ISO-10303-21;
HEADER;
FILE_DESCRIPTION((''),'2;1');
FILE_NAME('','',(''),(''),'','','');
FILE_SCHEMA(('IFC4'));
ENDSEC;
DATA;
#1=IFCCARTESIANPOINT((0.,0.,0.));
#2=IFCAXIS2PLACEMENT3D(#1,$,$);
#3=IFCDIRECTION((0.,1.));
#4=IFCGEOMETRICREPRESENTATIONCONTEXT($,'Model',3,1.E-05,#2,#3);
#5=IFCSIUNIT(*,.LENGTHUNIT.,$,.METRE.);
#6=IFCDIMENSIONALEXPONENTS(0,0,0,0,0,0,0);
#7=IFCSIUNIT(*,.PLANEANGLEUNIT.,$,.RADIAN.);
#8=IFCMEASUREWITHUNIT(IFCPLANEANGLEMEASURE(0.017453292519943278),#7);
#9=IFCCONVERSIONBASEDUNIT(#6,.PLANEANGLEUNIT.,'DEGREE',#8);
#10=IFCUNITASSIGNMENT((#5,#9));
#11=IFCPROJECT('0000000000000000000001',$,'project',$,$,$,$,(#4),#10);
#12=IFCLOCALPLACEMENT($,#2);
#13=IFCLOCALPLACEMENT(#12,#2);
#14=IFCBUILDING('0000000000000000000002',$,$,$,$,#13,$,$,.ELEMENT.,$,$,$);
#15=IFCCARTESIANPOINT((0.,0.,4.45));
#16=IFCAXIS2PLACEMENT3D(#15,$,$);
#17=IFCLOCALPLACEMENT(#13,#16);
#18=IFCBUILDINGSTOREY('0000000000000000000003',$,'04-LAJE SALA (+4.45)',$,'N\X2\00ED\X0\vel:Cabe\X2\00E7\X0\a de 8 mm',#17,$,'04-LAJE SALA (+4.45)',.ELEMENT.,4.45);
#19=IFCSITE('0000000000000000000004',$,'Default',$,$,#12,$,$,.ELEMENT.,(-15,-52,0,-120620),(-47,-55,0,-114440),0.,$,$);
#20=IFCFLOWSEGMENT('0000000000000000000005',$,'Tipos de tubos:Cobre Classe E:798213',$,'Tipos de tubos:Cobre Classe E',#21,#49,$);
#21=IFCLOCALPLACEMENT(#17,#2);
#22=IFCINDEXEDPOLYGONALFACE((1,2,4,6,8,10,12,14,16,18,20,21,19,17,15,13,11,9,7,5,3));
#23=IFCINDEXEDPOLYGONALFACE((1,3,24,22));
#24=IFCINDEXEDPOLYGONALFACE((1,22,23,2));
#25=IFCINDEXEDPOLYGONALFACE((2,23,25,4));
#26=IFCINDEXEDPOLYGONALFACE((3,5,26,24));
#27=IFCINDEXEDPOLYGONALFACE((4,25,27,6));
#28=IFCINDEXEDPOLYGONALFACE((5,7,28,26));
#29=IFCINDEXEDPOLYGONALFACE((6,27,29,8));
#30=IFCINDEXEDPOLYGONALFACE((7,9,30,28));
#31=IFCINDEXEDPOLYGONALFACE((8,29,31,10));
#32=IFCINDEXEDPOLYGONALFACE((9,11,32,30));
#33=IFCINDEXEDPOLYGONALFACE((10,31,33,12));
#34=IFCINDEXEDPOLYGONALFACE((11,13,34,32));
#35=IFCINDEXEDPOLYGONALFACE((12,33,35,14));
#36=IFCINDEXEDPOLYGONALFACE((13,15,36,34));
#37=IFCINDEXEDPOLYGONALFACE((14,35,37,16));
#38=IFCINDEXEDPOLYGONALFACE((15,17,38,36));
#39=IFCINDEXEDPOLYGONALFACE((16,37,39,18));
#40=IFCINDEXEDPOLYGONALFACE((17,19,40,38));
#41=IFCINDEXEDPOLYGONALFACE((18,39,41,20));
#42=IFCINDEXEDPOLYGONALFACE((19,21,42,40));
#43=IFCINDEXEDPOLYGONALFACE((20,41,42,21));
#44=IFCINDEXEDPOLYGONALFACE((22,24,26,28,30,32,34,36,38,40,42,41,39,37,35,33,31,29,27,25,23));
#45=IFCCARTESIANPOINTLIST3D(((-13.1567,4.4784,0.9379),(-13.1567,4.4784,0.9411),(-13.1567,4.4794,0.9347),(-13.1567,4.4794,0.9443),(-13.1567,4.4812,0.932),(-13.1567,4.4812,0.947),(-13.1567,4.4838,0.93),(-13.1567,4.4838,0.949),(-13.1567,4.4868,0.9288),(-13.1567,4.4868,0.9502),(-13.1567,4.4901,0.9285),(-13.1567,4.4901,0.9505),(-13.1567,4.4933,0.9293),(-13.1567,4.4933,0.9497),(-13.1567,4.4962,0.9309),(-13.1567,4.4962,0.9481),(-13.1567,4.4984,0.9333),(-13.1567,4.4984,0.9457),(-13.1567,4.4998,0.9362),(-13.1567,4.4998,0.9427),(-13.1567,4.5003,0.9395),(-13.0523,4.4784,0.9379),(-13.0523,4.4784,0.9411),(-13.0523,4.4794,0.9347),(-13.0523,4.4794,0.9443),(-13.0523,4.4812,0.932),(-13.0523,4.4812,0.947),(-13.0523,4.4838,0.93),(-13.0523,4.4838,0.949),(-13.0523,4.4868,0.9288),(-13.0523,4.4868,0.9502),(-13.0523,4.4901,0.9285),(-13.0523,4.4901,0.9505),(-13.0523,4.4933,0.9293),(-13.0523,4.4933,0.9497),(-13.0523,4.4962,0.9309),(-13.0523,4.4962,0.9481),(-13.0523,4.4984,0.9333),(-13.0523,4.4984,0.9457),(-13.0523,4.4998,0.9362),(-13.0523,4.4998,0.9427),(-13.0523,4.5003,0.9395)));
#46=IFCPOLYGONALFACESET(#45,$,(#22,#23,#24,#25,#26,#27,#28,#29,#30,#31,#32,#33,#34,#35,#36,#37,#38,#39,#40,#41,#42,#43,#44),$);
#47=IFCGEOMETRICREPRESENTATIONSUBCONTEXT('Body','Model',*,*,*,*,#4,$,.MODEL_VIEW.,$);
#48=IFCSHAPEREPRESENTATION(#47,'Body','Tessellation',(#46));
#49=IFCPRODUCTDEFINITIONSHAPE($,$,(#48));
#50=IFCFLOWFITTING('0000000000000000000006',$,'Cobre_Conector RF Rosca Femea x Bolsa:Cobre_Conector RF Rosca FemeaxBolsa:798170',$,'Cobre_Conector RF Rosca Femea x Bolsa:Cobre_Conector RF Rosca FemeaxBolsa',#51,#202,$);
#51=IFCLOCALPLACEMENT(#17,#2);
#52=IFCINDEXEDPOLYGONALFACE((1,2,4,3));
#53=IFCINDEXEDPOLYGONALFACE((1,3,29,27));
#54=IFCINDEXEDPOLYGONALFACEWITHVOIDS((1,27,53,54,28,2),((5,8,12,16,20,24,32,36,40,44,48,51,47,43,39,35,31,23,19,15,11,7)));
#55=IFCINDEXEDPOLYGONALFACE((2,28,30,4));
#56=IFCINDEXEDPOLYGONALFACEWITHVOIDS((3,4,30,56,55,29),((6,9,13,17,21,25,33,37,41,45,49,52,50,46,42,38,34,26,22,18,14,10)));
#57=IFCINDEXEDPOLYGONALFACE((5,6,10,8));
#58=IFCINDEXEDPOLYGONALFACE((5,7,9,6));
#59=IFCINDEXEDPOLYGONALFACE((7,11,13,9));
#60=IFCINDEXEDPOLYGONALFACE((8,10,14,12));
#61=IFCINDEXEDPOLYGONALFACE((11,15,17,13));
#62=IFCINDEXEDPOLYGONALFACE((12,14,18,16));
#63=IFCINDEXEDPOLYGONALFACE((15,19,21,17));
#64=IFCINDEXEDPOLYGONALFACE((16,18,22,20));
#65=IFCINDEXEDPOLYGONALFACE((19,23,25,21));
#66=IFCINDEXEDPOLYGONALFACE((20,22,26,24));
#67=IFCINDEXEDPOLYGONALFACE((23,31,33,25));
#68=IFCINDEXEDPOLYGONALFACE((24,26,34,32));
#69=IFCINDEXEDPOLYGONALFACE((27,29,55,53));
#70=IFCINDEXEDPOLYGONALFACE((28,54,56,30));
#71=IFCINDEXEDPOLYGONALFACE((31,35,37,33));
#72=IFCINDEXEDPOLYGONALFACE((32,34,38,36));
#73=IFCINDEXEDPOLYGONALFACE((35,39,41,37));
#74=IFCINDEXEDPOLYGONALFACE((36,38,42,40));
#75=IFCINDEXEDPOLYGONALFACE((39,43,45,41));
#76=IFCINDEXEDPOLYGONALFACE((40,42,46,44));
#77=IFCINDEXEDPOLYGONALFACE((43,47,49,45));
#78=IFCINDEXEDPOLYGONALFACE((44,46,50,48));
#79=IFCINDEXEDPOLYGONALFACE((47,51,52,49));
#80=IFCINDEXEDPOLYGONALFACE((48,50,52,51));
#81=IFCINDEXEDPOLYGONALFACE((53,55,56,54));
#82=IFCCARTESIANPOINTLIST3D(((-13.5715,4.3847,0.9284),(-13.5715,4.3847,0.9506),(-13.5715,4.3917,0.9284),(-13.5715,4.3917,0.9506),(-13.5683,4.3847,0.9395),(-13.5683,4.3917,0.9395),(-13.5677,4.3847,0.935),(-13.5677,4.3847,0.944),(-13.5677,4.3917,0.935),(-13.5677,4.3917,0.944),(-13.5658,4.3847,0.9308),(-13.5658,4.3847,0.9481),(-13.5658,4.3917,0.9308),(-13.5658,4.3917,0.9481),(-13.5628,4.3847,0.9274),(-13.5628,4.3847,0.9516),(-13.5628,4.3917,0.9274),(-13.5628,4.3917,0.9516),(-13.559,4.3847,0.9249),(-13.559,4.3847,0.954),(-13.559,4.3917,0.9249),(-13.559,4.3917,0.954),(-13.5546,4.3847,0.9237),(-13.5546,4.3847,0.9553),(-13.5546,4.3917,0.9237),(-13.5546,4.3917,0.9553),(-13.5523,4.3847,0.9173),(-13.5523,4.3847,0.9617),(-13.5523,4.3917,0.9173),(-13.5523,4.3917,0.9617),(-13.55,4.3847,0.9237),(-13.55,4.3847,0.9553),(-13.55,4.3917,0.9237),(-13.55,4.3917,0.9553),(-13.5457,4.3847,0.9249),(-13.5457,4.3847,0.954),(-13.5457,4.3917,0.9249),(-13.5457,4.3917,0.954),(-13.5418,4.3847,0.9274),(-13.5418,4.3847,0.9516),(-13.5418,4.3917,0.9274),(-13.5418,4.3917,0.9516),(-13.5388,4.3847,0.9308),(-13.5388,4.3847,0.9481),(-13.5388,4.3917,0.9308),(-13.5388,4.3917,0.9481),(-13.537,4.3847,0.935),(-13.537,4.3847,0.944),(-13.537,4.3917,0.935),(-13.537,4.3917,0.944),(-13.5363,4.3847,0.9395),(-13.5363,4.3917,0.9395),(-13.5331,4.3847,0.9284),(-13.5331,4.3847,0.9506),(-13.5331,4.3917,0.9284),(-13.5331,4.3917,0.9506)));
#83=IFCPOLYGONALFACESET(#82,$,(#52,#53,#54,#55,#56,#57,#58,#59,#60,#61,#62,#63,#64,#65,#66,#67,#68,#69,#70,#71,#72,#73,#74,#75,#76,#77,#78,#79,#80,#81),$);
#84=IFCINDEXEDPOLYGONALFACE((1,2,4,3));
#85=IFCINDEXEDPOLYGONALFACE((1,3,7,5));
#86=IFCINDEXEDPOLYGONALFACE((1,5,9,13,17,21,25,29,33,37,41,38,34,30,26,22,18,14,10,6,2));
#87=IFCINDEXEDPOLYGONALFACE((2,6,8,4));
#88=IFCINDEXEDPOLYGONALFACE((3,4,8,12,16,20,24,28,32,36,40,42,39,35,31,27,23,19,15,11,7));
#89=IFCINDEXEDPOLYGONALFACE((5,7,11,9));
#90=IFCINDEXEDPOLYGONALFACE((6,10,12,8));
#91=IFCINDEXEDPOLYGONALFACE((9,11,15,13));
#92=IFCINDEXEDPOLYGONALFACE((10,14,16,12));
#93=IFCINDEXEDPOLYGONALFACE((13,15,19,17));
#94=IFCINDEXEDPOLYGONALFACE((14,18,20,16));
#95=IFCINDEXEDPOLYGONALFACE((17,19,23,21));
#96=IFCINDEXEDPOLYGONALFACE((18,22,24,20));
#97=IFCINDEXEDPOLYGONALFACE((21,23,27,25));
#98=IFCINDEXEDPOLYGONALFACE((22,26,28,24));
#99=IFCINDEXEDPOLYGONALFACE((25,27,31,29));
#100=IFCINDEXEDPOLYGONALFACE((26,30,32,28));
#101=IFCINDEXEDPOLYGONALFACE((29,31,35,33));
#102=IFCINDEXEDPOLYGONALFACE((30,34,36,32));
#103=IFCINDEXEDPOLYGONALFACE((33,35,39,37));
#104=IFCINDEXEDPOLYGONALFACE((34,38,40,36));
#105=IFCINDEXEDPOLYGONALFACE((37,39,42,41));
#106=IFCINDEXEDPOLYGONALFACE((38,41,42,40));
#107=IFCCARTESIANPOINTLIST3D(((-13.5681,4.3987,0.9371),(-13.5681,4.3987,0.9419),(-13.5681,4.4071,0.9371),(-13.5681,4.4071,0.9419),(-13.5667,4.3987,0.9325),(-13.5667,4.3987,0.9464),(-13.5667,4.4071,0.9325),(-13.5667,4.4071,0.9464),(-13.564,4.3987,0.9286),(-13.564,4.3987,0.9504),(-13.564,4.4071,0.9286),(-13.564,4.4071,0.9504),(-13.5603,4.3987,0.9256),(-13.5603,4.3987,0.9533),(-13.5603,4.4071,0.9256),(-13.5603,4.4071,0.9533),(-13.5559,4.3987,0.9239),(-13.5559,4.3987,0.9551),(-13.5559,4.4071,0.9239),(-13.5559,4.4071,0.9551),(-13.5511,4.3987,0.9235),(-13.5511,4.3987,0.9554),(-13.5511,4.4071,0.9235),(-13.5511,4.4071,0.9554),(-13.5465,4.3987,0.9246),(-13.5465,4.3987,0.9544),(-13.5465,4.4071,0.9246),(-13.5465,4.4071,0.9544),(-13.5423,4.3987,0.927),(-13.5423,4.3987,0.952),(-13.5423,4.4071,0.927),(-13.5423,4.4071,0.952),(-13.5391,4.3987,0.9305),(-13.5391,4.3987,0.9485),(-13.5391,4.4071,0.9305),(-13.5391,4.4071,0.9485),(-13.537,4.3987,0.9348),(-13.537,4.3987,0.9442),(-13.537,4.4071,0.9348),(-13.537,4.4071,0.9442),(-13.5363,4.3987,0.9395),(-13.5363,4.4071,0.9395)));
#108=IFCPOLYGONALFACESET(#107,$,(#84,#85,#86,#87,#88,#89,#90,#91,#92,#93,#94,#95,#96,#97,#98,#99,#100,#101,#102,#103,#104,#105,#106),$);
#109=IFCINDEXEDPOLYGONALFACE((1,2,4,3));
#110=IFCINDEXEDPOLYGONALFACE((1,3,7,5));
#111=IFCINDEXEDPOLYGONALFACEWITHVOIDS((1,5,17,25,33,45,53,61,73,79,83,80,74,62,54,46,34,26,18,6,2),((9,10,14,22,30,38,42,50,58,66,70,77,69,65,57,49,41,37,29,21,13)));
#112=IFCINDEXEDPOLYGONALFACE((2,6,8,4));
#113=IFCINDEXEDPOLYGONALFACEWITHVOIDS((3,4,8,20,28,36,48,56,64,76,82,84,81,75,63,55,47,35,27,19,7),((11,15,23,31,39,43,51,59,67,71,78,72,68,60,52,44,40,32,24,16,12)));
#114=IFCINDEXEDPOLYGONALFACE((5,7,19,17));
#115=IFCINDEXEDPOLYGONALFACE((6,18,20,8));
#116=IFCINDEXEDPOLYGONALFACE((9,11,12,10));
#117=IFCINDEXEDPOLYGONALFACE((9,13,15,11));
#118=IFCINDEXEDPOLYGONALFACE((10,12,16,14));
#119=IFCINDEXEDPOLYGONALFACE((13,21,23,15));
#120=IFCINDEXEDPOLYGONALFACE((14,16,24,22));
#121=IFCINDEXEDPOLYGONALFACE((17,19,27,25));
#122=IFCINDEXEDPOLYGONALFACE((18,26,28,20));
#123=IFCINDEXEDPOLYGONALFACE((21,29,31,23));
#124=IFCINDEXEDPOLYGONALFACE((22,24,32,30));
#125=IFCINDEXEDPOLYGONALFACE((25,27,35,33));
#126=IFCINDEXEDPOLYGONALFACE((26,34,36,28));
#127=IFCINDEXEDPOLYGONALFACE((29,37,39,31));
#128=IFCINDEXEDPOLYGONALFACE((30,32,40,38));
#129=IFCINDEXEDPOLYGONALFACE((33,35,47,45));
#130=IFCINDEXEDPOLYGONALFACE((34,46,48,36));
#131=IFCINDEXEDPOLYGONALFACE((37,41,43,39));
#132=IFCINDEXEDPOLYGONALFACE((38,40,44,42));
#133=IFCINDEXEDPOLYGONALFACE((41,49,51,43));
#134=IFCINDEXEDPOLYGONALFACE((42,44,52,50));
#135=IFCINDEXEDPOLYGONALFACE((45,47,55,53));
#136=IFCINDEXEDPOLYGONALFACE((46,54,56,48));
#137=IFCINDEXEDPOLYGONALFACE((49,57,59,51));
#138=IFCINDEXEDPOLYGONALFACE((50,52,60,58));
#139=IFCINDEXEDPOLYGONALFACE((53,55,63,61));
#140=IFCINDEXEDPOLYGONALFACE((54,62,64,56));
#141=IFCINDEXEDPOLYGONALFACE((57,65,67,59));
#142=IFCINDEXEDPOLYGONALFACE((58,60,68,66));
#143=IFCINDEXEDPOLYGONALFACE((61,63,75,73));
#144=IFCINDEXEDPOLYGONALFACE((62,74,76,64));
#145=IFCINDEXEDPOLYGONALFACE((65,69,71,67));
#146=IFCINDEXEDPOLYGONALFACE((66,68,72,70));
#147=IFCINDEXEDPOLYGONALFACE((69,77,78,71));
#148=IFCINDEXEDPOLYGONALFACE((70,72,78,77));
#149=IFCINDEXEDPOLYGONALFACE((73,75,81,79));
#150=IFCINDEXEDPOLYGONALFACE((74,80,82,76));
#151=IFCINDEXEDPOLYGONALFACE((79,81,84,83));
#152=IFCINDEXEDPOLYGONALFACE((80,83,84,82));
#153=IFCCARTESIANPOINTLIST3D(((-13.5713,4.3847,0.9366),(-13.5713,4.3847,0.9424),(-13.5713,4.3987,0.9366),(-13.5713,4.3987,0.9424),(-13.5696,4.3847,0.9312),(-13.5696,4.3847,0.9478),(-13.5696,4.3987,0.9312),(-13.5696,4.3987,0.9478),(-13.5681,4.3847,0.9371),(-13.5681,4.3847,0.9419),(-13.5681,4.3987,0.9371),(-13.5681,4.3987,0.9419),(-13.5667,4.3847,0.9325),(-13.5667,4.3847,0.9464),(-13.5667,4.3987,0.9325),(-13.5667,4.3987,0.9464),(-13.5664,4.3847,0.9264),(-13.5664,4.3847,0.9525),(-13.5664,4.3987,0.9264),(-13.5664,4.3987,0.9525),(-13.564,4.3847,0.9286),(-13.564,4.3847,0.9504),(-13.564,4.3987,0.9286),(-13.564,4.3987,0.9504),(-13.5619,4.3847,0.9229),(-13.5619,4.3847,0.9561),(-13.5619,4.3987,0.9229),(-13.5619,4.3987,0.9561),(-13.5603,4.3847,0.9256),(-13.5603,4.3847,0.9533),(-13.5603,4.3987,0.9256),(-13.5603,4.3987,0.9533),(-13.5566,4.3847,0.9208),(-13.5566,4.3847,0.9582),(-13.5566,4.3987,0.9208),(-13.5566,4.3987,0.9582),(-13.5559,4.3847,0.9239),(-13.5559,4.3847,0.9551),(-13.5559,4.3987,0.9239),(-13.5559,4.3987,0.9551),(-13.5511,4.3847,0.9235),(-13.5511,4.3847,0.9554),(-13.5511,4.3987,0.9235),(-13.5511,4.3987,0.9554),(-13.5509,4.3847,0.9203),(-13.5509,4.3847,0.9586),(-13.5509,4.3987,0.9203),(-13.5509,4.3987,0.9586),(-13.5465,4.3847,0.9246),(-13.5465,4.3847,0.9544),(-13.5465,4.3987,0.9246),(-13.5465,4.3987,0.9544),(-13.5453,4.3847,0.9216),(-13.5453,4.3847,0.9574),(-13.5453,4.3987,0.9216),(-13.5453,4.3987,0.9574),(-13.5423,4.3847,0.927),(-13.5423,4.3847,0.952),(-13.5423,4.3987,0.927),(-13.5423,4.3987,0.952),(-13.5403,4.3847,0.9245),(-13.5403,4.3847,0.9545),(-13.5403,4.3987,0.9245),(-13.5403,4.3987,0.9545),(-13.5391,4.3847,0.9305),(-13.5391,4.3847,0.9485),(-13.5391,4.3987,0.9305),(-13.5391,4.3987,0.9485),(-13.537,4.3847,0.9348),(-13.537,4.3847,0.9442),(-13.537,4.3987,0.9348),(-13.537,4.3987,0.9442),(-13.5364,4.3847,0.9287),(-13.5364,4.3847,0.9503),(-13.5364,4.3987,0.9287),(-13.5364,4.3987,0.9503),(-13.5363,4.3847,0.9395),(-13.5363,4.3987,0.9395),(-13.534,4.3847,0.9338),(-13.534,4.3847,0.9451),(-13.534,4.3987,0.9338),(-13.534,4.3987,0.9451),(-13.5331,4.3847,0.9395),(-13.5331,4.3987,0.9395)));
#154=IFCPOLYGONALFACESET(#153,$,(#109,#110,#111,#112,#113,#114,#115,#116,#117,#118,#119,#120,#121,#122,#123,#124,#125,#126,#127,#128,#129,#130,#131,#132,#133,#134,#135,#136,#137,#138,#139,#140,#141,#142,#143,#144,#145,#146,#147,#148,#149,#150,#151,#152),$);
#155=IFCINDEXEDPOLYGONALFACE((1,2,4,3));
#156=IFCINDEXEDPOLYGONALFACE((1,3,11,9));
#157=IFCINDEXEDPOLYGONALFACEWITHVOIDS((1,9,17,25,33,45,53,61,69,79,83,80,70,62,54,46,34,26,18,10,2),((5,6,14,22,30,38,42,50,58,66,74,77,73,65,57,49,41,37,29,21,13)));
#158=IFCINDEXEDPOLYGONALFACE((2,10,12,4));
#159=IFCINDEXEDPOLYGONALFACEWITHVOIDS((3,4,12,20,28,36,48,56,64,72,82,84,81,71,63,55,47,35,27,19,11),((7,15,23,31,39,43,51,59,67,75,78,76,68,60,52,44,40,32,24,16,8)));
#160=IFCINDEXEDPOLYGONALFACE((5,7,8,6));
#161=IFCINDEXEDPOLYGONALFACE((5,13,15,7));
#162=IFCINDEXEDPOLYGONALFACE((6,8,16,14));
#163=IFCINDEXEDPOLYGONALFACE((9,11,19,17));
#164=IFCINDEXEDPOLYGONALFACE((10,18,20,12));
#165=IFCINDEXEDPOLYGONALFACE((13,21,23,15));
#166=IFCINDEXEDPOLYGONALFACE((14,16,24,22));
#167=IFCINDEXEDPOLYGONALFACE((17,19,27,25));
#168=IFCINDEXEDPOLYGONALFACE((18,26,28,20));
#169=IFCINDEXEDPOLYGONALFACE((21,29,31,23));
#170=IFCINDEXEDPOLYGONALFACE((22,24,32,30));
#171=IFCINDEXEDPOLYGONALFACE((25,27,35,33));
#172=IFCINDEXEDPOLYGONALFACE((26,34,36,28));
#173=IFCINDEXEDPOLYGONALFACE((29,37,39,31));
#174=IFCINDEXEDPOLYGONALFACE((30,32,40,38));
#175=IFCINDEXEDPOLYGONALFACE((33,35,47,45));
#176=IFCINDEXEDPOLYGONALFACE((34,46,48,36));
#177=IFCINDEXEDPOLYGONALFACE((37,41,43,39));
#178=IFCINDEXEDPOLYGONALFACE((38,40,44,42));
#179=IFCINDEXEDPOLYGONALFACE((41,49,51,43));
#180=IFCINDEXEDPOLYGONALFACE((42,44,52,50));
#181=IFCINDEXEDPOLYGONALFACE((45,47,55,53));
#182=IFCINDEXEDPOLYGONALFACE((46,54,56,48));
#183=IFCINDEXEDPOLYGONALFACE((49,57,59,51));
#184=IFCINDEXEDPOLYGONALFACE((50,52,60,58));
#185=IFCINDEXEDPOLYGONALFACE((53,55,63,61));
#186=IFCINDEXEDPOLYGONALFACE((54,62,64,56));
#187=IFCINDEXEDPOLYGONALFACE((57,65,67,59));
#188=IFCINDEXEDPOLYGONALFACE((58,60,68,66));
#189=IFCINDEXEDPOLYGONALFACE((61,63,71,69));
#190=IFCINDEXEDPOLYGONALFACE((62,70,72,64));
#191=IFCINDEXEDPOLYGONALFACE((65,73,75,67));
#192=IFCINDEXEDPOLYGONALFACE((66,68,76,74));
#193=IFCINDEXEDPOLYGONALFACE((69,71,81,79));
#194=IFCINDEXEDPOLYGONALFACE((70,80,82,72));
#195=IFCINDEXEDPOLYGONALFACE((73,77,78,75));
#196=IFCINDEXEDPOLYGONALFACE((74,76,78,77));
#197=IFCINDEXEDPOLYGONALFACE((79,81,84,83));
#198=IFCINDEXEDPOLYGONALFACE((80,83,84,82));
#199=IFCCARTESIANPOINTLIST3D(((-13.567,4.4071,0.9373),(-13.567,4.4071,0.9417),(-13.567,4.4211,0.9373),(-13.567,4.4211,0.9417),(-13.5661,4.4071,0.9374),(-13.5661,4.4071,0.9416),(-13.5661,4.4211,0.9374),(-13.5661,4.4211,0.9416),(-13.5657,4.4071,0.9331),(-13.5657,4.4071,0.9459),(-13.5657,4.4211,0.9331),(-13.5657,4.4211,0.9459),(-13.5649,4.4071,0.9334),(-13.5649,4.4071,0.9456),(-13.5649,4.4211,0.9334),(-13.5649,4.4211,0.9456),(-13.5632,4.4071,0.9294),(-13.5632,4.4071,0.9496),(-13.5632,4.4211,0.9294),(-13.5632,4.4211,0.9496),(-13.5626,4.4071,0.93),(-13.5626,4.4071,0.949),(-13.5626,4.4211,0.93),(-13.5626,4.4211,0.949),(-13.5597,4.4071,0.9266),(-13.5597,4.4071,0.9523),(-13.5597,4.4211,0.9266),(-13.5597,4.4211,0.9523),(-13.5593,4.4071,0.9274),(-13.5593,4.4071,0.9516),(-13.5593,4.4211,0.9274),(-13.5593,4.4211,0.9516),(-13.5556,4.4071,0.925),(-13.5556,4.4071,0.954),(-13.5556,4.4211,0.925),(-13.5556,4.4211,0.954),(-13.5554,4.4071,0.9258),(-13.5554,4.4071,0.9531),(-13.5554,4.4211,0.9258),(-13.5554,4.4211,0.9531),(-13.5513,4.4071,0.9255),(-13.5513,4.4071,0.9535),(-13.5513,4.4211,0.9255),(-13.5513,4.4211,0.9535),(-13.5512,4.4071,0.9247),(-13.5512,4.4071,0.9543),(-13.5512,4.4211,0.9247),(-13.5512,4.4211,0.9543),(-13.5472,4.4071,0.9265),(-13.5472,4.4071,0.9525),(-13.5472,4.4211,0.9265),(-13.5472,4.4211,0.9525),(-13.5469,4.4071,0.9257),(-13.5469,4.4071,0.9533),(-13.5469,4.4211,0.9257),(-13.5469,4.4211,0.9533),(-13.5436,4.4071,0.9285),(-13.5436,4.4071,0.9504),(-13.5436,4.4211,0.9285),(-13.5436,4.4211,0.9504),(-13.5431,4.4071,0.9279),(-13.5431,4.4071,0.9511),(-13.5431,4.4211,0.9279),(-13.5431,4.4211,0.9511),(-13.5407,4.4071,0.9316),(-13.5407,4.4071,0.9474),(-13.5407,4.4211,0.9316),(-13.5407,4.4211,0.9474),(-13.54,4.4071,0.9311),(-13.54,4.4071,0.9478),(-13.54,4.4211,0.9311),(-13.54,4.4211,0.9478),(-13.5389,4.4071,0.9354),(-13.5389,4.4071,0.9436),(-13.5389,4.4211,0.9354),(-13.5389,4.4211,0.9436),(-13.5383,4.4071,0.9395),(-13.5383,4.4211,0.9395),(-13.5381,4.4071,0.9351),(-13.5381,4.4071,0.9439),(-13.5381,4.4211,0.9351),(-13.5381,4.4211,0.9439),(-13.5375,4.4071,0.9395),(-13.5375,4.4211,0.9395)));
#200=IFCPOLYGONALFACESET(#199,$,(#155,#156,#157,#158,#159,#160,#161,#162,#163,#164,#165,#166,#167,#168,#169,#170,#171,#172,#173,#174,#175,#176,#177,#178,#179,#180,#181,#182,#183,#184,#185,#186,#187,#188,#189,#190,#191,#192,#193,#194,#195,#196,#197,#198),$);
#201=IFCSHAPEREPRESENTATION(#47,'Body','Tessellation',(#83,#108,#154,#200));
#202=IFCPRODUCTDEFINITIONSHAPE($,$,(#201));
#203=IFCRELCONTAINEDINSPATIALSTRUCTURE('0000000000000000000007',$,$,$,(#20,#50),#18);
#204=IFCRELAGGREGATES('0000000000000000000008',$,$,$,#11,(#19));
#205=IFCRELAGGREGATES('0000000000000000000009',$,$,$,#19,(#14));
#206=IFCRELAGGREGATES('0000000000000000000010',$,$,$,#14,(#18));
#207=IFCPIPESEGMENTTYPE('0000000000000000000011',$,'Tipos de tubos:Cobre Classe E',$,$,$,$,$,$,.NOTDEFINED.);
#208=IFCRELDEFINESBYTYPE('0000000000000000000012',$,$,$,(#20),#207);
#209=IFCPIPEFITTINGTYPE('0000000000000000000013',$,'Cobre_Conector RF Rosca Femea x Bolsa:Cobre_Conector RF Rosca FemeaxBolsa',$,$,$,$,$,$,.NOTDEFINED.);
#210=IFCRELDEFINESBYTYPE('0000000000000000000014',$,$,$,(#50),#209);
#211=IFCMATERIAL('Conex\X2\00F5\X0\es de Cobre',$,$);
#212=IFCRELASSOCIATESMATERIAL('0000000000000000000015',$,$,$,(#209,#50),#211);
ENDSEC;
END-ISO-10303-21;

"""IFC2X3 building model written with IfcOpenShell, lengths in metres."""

from ifc_helpers import new_model, entity, si_unit, converted_unit, direction, frame, frame_2d, origin, origin_2d_with_axis, place, context, subcontext, project, spatial, polyline, circle_curve, parameter, trimmed, segment, composite_curve, circle, hollow_circle, outline, extrude, source, transform, mapped, material, type_object, type_shapes, element, save


model = new_model("IFC2X3")

# Units and contexts
model_context = context("Model", 3, precision=1e-05, world=origin(), true_north=direction((0.0, 1.0)))
body_context = subcontext(model_context, "Body", "Model", "MODEL_VIEW")
ifc_project = project(units=[si_unit("LENGTHUNIT", "METRE"), converted_unit("PLANEANGLEUNIT", "DEGREE", entity("IfcPlaneAngleMeasure", 0.017453292519943278), si_unit("PLANEANGLEUNIT", "RADIAN"), dimensions=[0, 0, 0, 0, 0, 0, 0])], contexts=[model_context])

# Site, building, storey
site_placement = place(None, origin())
site = spatial("IfcSite", under=ifc_project, at=site_placement, Name="Default", CompositionType="ELEMENT", RefLatitude=(-15, -52, 0, -120620), RefLongitude=(-47, -55, 0, -114440), RefElevation=0.0)
building_placement = place(site_placement, origin())
building = spatial("IfcBuilding", under=site, at=building_placement, CompositionType="ELEMENT")
storey_placement = place(building_placement, frame((0.0, 0.0, 4.45)))
storey = spatial("IfcBuildingStorey", under=building, at=storey_placement, Name="04-LAJE SALA (+4.45)", ObjectType="Nível:Cabeça de 8 mm", LongName="04-LAJE SALA (+4.45)", CompositionType="ELEMENT", Elevation=4.45)

# Flow segment
pipe_segment_type_1 = type_object("IfcPipeSegmentType", Name="Tipos de tubos:Cobre Classe E", PredefinedType="NOTDEFINED")
flow_segment_1_placement = place(storey_placement, origin())
element("IfcFlowSegment", 1, at=flow_segment_1_placement, inside=storey, type_object=pipe_segment_type_1, Name="Tipos de tubos:Cobre Classe E:798213", ObjectType="Tipos de tubos:Cobre Classe E", context=body_context, shape_type="SweptSolid", body=[
    extrude(circle(Radius=0.011, at=origin_2d_with_axis()), frame((-13.1567, 4.4893, 0.9395), z_axis=(1.0, 0.0, 0.0), x_axis=(0.0, 1.0, 0.0)), (0.0, 0.0, 1.0), 0.1045),
])

# Flow fitting
ifc_material_1 = material(Name="Conexões de Cobre")
pipe_fitting_type_1 = type_object("IfcPipeFittingType", Name="Cobre_Conector RF Rosca Femea x Bolsa:Cobre_Conector RF Rosca FemeaxBolsa", PredefinedType="NOTDEFINED", material=ifc_material_1)
shared_shape_1 = source(origin(), body_context, "Body", "SweptSolid", [
    extrude(outline(polyline([(-0.0111, -0.0192), (0.0111, -0.0192), (0.0222, 0.0), (0.0111, 0.0192), (-0.0111, 0.0192), (-0.0222, 0.0), (-0.0111, -0.0192)]), holes=[composite_curve([segment(trimmed(circle_curve(frame_2d((0.0, 0.0), x_axis=(0.0, 1.0)), 0.016), [parameter(0.0)], [parameter(180.0)], True, "PARAMETER"), False, "CONTINUOUS"), segment(trimmed(circle_curve(frame_2d((0.0, 0.0), x_axis=(0.0, 1.0)), 0.016), [parameter(180.0)], [parameter(0.0)], True, "PARAMETER"), False, "CONTINUOUS")], self_intersect=False)]), frame((0.0294, 0.0, 0.0), z_axis=(1.0, 0.0, 0.0), x_axis=(0.0, 0.0, -1.0)), (0.0, 0.0, 1.0), 0.007),
    extrude(circle(Radius=0.016, at=frame_2d((0.0, 0.0), x_axis=(1.0, 0.0))), frame((0.014, 0.0, 0.0), z_axis=(1.0, 0.0, 0.0), x_axis=(0.0, 1.0, 0.0)), (0.0, 0.0, 1.0), 0.0084),
    extrude(hollow_circle(Radius=0.0192, WallThickness=0.0032, at=frame_2d((0.0, 0.0), x_axis=(1.0, 0.0))), frame((0.0224, 0.0, 0.0), z_axis=(1.0, 0.0, 0.0), x_axis=(0.0, 1.0, 0.0)), (0.0, 0.0, 1.0), 0.014),
    extrude(hollow_circle(Radius=0.0148, WallThickness=0.0008, at=frame_2d((0.0, 0.0), x_axis=(1.0, 0.0))), frame((0.0, 0.0, 0.0), z_axis=(1.0, 0.0, 0.0), x_axis=(0.0, 1.0, 0.0)), (0.0, 0.0, 1.0), 0.014),
])
type_shapes(pipe_fitting_type_1, [shared_shape_1])
for number, where, z_axis, x_axis, name in (
    (2, (-13.5523, 4.4211, 0.9395), (0.0, 0.0, 1.0), (0.0, -1.0, 0.0), "Cobre_Conector RF Rosca Femea x Bolsa:Cobre_Conector RF Rosca FemeaxBolsa:798170"),
):
    element("IfcFlowFitting", number, at=place(storey_placement, frame(where, z_axis=z_axis, x_axis=x_axis)), inside=storey, type_object=pipe_fitting_type_1, material=ifc_material_1, Name=name, ObjectType="Cobre_Conector RF Rosca Femea x Bolsa:Cobre_Conector RF Rosca FemeaxBolsa", context=body_context, shape_type="MappedRepresentation", body=[
        mapped(shared_shape_1, transform((0.0, 0.0, 0.0), scale=1.0)),
    ])

save(model, "model.ifc")
